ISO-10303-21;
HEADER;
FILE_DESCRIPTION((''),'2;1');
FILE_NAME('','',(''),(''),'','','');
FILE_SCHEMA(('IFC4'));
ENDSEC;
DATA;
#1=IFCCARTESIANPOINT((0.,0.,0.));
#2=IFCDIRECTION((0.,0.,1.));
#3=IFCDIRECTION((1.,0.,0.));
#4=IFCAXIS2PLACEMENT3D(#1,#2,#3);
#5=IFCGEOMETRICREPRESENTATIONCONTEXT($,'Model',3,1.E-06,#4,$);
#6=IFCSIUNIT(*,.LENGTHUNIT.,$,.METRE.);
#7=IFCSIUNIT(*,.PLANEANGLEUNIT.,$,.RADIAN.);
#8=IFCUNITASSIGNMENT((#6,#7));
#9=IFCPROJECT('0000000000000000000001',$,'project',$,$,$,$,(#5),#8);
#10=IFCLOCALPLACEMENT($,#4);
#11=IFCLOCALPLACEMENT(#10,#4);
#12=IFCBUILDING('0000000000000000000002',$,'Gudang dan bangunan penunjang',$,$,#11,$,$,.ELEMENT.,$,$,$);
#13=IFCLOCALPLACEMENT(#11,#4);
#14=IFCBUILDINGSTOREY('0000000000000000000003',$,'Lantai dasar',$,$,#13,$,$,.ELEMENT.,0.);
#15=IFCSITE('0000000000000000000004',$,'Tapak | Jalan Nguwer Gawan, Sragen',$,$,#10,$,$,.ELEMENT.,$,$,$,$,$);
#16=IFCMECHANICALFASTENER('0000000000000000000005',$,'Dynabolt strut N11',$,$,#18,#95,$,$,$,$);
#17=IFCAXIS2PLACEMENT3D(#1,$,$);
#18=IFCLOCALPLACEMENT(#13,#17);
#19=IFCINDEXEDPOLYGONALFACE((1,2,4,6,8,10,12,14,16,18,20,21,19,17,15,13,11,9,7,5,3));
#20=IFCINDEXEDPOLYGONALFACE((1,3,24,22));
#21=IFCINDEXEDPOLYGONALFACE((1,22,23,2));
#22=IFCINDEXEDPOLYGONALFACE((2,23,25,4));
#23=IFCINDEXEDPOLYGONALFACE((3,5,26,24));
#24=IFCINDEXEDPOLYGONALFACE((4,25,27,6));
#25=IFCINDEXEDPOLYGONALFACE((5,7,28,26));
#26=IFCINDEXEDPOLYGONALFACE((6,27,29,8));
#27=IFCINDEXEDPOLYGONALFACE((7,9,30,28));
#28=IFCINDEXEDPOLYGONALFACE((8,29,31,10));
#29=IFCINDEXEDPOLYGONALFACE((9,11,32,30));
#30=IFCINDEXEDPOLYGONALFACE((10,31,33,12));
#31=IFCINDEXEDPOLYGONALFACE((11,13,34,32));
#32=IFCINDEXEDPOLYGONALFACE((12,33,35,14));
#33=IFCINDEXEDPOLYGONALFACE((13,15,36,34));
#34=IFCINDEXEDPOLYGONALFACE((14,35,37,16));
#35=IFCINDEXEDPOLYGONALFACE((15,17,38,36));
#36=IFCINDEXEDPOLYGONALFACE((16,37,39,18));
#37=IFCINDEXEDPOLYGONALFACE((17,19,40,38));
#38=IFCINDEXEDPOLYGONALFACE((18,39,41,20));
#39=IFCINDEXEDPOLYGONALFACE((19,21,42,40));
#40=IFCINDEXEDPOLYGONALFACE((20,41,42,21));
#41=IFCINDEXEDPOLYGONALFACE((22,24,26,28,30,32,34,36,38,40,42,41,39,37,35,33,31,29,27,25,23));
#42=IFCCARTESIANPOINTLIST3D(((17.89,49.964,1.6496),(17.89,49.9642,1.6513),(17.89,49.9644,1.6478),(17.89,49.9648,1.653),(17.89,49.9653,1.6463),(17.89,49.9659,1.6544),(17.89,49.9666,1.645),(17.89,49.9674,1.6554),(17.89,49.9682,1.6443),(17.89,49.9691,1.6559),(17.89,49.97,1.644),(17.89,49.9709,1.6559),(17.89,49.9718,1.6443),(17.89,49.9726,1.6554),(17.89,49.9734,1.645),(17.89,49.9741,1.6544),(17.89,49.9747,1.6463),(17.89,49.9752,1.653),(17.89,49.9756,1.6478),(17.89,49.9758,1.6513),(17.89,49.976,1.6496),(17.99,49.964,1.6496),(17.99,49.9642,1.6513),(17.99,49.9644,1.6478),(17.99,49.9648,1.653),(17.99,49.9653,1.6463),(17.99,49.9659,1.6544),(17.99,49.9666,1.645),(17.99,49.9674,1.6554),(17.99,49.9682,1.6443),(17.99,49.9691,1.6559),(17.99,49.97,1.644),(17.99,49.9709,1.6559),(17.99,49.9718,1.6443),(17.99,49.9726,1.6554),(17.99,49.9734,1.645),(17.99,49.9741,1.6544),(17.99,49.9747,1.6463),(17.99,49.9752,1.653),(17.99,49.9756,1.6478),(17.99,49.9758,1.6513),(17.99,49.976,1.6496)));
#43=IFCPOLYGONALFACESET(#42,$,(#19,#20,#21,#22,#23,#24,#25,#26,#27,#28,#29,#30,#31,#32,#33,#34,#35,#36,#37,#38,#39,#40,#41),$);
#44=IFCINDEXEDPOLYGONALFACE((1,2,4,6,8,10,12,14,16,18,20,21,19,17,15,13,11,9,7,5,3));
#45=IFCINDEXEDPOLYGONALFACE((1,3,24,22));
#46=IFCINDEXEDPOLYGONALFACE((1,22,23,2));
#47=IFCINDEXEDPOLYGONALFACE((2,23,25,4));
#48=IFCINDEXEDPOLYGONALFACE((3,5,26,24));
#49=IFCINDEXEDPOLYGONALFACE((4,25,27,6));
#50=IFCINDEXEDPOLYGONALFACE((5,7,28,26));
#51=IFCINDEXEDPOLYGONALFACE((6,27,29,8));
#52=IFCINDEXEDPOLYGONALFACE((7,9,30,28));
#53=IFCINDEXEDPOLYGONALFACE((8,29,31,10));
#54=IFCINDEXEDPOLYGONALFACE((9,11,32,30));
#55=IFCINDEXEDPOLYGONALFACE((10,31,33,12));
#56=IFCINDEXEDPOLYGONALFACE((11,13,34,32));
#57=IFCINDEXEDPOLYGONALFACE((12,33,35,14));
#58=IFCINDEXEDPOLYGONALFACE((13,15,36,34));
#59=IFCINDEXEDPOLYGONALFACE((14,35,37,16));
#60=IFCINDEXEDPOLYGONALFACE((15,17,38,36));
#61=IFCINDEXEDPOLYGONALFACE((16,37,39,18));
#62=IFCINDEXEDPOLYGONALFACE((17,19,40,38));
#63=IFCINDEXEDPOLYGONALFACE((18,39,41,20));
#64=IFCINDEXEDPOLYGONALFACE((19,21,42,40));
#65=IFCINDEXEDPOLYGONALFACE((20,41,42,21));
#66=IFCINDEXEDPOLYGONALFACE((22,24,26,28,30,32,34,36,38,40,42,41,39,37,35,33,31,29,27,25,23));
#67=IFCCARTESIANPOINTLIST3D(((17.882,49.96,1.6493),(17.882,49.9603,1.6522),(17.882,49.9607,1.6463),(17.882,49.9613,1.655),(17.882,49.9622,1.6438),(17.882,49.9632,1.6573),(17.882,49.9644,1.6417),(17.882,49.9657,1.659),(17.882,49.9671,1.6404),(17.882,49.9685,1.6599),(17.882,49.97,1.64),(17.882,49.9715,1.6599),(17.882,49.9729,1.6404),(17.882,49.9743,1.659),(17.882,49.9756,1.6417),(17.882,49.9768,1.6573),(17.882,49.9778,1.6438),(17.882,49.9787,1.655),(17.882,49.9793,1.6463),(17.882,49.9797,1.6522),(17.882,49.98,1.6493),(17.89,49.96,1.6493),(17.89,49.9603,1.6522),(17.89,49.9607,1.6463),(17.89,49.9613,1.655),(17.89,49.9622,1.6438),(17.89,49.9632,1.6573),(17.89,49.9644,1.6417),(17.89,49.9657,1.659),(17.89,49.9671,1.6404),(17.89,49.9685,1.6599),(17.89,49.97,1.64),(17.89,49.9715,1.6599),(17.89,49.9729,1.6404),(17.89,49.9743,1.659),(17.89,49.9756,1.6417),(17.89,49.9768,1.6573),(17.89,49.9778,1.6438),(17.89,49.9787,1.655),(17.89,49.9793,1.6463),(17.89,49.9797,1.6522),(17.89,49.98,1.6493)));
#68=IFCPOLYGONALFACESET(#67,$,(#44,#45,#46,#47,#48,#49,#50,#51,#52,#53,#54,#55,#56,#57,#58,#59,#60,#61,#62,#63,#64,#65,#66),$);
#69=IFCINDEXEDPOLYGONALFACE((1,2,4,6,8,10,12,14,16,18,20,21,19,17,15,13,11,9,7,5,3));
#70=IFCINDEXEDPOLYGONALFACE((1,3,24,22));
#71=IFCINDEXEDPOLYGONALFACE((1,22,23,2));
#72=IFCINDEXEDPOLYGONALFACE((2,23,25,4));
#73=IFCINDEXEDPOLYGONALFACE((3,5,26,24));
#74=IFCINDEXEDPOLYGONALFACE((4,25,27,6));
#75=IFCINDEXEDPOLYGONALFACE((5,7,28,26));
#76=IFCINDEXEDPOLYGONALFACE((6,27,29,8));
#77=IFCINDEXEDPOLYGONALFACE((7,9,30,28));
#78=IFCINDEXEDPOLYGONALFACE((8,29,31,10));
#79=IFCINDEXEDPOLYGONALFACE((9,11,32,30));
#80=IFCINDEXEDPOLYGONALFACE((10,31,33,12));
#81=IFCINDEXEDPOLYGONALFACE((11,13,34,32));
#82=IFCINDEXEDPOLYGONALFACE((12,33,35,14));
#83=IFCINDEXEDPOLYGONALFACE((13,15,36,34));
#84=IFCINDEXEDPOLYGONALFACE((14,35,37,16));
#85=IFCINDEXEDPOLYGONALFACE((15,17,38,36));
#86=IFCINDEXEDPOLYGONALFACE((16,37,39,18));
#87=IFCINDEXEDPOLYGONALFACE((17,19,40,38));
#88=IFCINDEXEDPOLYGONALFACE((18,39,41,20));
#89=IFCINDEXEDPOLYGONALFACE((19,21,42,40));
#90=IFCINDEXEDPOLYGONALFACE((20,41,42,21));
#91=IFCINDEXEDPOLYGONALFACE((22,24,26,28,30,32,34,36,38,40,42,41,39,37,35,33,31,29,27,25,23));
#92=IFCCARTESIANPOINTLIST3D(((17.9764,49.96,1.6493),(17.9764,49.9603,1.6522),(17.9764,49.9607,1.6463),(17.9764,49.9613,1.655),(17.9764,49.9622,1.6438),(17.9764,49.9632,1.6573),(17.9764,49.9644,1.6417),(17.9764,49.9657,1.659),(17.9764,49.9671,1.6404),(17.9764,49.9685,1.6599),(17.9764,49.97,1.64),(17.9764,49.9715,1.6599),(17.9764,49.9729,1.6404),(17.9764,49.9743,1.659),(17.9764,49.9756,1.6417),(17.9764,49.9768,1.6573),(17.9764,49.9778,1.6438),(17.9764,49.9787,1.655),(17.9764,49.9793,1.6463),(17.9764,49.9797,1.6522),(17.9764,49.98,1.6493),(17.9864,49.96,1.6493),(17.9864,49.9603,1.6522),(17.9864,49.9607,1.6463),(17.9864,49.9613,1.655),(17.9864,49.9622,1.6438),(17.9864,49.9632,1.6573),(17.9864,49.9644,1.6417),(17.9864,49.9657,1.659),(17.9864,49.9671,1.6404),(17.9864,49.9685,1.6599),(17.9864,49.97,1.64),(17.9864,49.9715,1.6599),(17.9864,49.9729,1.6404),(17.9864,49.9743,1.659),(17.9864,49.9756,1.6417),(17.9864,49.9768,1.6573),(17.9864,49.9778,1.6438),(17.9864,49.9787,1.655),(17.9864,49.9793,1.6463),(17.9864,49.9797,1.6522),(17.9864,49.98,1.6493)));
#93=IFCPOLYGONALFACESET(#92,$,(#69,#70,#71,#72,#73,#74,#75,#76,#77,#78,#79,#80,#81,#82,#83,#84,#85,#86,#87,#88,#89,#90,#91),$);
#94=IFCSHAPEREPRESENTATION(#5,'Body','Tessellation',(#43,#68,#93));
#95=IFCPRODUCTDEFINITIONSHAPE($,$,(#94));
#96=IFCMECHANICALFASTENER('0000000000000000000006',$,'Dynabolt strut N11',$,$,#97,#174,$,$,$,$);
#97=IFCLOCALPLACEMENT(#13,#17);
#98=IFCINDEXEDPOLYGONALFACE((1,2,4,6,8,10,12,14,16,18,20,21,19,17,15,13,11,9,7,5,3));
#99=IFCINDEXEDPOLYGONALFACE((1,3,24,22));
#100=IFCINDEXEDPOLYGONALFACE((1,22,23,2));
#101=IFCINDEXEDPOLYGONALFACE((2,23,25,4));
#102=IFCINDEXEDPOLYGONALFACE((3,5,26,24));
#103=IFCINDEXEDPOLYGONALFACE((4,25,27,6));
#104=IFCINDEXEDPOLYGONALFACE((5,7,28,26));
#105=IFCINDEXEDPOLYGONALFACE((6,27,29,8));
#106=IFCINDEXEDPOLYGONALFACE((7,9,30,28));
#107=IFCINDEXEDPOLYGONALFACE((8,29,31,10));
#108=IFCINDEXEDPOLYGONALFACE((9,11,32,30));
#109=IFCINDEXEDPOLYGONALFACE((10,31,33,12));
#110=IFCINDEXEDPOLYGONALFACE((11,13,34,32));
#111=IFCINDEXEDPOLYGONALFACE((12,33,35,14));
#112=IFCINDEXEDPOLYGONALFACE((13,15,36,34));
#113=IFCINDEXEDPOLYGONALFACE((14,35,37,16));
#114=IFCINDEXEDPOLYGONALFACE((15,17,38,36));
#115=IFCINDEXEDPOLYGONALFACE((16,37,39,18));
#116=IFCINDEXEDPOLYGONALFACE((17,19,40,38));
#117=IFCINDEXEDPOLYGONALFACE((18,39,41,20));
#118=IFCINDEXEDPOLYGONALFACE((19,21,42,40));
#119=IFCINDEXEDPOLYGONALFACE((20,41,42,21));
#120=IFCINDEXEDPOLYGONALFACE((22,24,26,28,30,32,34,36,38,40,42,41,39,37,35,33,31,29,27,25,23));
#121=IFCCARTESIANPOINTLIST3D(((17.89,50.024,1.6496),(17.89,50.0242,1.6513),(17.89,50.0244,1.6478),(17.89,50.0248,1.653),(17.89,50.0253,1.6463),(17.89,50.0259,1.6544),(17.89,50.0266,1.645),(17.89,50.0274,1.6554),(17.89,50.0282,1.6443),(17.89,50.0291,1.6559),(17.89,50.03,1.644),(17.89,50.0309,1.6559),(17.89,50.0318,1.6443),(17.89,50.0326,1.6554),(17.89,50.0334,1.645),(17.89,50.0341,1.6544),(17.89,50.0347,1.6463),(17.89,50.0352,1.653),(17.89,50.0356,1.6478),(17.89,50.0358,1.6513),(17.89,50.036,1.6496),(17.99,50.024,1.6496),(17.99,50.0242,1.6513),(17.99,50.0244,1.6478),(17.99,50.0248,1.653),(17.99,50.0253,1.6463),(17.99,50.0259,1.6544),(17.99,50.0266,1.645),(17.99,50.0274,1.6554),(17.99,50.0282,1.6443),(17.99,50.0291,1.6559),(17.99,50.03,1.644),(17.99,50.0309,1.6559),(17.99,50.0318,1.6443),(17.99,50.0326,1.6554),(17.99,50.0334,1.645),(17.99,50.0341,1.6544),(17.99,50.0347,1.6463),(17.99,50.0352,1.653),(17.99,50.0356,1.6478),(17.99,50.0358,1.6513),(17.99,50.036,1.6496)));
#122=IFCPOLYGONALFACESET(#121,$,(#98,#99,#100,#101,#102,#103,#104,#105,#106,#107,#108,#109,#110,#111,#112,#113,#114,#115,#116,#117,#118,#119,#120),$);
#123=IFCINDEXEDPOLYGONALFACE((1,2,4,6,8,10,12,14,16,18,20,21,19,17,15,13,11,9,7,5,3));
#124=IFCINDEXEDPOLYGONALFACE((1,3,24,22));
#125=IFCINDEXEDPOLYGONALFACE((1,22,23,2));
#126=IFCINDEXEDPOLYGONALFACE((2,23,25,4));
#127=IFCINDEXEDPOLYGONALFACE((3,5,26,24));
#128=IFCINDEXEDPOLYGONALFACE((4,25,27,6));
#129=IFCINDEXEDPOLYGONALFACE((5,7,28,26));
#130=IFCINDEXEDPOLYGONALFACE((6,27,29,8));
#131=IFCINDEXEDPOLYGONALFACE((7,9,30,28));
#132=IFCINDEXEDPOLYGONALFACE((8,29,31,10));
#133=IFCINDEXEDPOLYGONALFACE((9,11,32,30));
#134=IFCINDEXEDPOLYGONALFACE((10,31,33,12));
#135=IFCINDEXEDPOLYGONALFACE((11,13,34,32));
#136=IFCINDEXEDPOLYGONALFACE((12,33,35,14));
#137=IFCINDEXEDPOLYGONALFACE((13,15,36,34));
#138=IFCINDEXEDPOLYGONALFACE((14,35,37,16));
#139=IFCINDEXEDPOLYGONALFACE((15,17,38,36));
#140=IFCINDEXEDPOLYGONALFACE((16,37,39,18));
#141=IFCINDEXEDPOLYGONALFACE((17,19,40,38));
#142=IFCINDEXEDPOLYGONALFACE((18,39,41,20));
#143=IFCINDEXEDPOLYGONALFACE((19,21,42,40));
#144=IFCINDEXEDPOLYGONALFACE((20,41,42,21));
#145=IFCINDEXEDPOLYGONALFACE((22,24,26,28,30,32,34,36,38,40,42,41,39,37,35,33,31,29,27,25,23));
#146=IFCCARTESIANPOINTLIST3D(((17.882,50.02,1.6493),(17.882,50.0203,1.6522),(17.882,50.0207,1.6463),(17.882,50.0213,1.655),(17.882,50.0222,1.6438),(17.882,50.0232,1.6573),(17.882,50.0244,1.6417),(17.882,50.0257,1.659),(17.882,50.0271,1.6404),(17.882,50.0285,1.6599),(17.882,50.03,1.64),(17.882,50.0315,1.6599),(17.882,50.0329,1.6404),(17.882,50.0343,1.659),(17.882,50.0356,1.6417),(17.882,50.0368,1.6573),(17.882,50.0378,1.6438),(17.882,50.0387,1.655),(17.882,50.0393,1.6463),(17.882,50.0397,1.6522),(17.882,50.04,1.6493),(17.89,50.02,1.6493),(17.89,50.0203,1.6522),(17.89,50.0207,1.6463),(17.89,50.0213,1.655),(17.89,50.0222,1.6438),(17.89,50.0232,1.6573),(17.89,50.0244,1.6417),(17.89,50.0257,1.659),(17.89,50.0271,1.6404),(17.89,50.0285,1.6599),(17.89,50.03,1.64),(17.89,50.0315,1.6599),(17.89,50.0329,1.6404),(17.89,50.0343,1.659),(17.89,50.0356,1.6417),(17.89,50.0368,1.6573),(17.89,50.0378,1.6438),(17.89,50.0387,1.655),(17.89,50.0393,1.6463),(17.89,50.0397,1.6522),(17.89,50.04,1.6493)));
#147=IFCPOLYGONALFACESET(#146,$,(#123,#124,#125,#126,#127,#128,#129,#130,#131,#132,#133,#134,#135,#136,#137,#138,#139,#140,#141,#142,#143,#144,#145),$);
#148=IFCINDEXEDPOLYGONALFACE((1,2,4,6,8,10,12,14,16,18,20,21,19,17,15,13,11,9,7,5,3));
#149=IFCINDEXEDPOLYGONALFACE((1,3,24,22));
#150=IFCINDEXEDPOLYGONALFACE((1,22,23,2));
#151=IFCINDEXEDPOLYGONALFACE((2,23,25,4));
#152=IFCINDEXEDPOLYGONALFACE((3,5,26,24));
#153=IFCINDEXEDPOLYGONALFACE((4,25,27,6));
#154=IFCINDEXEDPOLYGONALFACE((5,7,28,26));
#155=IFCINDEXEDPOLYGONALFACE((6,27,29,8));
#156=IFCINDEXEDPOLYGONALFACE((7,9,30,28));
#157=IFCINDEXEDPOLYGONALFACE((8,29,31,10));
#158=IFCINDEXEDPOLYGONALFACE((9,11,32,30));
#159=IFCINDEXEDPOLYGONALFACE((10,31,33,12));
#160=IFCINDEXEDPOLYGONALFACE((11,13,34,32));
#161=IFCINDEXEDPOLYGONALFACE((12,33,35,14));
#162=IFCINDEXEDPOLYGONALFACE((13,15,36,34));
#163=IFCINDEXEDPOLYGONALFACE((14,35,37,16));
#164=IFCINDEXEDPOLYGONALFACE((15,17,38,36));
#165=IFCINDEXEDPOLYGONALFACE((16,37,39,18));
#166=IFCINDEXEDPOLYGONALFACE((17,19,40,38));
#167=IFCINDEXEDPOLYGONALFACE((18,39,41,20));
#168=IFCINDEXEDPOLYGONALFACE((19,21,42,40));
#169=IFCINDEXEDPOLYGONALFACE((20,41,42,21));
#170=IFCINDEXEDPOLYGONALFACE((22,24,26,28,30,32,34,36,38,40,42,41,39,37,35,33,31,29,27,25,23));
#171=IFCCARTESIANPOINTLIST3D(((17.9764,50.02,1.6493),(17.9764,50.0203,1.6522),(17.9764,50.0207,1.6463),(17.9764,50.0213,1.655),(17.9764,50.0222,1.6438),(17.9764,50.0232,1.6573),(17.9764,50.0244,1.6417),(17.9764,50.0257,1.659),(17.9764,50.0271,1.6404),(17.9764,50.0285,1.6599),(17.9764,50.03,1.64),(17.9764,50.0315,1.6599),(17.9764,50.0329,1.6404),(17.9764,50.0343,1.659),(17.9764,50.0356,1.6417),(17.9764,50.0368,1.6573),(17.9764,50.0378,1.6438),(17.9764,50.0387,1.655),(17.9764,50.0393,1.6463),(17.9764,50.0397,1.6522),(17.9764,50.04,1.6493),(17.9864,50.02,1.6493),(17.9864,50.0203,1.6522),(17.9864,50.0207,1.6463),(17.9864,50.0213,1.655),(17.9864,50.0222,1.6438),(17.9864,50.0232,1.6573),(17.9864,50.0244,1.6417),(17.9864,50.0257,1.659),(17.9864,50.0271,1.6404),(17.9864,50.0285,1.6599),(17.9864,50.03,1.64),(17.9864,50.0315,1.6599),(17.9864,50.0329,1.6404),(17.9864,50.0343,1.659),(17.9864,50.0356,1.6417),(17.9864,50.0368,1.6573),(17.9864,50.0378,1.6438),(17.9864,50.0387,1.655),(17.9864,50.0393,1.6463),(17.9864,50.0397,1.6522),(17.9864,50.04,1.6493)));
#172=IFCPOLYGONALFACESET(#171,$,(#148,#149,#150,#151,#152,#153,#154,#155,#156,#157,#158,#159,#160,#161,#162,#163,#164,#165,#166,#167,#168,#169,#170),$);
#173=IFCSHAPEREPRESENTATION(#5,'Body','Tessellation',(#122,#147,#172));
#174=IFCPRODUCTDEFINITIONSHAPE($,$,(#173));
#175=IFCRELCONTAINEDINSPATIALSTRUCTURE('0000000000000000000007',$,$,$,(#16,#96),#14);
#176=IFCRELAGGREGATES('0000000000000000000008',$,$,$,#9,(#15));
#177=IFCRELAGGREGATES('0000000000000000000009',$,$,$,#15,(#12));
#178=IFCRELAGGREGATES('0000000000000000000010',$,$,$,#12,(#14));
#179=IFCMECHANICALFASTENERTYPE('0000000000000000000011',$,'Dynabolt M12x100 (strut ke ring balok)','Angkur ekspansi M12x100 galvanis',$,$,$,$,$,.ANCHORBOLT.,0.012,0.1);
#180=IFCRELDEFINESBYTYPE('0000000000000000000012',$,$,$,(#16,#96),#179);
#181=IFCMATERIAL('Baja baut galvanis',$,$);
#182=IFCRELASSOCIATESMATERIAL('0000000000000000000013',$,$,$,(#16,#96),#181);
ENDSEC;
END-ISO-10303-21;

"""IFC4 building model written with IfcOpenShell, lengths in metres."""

from ifc_helpers import new_model, si_unit, frame, origin_with_axes, place, context, project, spatial, circle, extrude, source, transform, mapped, material, type_object, type_shapes, element, save


model = new_model("IFC4")

# Units and contexts
model_context = context("Model", 3, precision=1e-06, world=origin_with_axes())
ifc_project = project(units=[si_unit("LENGTHUNIT", "METRE"), si_unit("PLANEANGLEUNIT", "RADIAN")], contexts=[model_context])

# Site, building, storey
site_placement = place(None, origin_with_axes())
site = spatial("IfcSite", under=ifc_project, at=site_placement, Name="Tapak | Jalan Nguwer Gawan, Sragen", CompositionType="ELEMENT")
building_placement = place(site_placement, origin_with_axes())
building = spatial("IfcBuilding", under=site, at=building_placement, Name="Gudang dan bangunan penunjang", CompositionType="ELEMENT")
storey_placement = place(building_placement, origin_with_axes())
storey = spatial("IfcBuildingStorey", under=building, at=storey_placement, Name="Lantai dasar", CompositionType="ELEMENT", Elevation=0.0)

# Mechanical fasteners
ifc_material = material(Name="Baja baut galvanis")
mechanical_fastener_type = type_object("IfcMechanicalFastenerType", Name="Dynabolt M12x100 (strut ke ring balok)", Description="Angkur ekspansi M12x100 galvanis", NominalDiameter=0.012, NominalLength=0.1, PredefinedType="ANCHORBOLT")
shared_shape = source(origin_with_axes(), model_context, "Body", "SweptSolid", [
    extrude(circle(Radius=0.006), origin_with_axes(), (0.0, 0.0, 1.0), 0.1),
    extrude(circle(Radius=0.01), frame((0.0, 0.0, -0.008), z_axis=(0.0, 0.0, 1.0), x_axis=(1.0, 0.0, 0.0)), (0.0, 0.0, 1.0), 0.008),
    extrude(circle(Radius=0.01), frame((0.0, 0.0, 0.0864), z_axis=(0.0, 0.0, 1.0), x_axis=(1.0, 0.0, 0.0)), (0.0, 0.0, 1.0), 0.01),
])
type_shapes(mechanical_fastener_type, [shared_shape])
placement = place(None, origin_with_axes())
element("IfcMechanicalFastener", 1, at=placement, inside=storey, type_object=mechanical_fastener_type, material=ifc_material, Name="Dynabolt strut N11", context=model_context, shape_type="MappedRepresentation", body=[
    mapped(shared_shape, transform((17.89, 49.97, 1.65), x_axis=(0.0, 0.0, -1.0), y_axis=(0.0, 1.0, 0.0), z_axis=(1.0, 0.0, 0.0), scale=1.0)),
])
element("IfcMechanicalFastener", 2, at=placement, inside=storey, type_object=mechanical_fastener_type, material=ifc_material, Name="Dynabolt strut N11", context=model_context, shape_type="MappedRepresentation", body=[
    mapped(shared_shape, transform((17.89, 50.03, 1.65), x_axis=(0.0, 0.0, -1.0), y_axis=(0.0, 1.0, 0.0), z_axis=(1.0, 0.0, 0.0), scale=1.0)),
])

save(model, "model.ifc")
